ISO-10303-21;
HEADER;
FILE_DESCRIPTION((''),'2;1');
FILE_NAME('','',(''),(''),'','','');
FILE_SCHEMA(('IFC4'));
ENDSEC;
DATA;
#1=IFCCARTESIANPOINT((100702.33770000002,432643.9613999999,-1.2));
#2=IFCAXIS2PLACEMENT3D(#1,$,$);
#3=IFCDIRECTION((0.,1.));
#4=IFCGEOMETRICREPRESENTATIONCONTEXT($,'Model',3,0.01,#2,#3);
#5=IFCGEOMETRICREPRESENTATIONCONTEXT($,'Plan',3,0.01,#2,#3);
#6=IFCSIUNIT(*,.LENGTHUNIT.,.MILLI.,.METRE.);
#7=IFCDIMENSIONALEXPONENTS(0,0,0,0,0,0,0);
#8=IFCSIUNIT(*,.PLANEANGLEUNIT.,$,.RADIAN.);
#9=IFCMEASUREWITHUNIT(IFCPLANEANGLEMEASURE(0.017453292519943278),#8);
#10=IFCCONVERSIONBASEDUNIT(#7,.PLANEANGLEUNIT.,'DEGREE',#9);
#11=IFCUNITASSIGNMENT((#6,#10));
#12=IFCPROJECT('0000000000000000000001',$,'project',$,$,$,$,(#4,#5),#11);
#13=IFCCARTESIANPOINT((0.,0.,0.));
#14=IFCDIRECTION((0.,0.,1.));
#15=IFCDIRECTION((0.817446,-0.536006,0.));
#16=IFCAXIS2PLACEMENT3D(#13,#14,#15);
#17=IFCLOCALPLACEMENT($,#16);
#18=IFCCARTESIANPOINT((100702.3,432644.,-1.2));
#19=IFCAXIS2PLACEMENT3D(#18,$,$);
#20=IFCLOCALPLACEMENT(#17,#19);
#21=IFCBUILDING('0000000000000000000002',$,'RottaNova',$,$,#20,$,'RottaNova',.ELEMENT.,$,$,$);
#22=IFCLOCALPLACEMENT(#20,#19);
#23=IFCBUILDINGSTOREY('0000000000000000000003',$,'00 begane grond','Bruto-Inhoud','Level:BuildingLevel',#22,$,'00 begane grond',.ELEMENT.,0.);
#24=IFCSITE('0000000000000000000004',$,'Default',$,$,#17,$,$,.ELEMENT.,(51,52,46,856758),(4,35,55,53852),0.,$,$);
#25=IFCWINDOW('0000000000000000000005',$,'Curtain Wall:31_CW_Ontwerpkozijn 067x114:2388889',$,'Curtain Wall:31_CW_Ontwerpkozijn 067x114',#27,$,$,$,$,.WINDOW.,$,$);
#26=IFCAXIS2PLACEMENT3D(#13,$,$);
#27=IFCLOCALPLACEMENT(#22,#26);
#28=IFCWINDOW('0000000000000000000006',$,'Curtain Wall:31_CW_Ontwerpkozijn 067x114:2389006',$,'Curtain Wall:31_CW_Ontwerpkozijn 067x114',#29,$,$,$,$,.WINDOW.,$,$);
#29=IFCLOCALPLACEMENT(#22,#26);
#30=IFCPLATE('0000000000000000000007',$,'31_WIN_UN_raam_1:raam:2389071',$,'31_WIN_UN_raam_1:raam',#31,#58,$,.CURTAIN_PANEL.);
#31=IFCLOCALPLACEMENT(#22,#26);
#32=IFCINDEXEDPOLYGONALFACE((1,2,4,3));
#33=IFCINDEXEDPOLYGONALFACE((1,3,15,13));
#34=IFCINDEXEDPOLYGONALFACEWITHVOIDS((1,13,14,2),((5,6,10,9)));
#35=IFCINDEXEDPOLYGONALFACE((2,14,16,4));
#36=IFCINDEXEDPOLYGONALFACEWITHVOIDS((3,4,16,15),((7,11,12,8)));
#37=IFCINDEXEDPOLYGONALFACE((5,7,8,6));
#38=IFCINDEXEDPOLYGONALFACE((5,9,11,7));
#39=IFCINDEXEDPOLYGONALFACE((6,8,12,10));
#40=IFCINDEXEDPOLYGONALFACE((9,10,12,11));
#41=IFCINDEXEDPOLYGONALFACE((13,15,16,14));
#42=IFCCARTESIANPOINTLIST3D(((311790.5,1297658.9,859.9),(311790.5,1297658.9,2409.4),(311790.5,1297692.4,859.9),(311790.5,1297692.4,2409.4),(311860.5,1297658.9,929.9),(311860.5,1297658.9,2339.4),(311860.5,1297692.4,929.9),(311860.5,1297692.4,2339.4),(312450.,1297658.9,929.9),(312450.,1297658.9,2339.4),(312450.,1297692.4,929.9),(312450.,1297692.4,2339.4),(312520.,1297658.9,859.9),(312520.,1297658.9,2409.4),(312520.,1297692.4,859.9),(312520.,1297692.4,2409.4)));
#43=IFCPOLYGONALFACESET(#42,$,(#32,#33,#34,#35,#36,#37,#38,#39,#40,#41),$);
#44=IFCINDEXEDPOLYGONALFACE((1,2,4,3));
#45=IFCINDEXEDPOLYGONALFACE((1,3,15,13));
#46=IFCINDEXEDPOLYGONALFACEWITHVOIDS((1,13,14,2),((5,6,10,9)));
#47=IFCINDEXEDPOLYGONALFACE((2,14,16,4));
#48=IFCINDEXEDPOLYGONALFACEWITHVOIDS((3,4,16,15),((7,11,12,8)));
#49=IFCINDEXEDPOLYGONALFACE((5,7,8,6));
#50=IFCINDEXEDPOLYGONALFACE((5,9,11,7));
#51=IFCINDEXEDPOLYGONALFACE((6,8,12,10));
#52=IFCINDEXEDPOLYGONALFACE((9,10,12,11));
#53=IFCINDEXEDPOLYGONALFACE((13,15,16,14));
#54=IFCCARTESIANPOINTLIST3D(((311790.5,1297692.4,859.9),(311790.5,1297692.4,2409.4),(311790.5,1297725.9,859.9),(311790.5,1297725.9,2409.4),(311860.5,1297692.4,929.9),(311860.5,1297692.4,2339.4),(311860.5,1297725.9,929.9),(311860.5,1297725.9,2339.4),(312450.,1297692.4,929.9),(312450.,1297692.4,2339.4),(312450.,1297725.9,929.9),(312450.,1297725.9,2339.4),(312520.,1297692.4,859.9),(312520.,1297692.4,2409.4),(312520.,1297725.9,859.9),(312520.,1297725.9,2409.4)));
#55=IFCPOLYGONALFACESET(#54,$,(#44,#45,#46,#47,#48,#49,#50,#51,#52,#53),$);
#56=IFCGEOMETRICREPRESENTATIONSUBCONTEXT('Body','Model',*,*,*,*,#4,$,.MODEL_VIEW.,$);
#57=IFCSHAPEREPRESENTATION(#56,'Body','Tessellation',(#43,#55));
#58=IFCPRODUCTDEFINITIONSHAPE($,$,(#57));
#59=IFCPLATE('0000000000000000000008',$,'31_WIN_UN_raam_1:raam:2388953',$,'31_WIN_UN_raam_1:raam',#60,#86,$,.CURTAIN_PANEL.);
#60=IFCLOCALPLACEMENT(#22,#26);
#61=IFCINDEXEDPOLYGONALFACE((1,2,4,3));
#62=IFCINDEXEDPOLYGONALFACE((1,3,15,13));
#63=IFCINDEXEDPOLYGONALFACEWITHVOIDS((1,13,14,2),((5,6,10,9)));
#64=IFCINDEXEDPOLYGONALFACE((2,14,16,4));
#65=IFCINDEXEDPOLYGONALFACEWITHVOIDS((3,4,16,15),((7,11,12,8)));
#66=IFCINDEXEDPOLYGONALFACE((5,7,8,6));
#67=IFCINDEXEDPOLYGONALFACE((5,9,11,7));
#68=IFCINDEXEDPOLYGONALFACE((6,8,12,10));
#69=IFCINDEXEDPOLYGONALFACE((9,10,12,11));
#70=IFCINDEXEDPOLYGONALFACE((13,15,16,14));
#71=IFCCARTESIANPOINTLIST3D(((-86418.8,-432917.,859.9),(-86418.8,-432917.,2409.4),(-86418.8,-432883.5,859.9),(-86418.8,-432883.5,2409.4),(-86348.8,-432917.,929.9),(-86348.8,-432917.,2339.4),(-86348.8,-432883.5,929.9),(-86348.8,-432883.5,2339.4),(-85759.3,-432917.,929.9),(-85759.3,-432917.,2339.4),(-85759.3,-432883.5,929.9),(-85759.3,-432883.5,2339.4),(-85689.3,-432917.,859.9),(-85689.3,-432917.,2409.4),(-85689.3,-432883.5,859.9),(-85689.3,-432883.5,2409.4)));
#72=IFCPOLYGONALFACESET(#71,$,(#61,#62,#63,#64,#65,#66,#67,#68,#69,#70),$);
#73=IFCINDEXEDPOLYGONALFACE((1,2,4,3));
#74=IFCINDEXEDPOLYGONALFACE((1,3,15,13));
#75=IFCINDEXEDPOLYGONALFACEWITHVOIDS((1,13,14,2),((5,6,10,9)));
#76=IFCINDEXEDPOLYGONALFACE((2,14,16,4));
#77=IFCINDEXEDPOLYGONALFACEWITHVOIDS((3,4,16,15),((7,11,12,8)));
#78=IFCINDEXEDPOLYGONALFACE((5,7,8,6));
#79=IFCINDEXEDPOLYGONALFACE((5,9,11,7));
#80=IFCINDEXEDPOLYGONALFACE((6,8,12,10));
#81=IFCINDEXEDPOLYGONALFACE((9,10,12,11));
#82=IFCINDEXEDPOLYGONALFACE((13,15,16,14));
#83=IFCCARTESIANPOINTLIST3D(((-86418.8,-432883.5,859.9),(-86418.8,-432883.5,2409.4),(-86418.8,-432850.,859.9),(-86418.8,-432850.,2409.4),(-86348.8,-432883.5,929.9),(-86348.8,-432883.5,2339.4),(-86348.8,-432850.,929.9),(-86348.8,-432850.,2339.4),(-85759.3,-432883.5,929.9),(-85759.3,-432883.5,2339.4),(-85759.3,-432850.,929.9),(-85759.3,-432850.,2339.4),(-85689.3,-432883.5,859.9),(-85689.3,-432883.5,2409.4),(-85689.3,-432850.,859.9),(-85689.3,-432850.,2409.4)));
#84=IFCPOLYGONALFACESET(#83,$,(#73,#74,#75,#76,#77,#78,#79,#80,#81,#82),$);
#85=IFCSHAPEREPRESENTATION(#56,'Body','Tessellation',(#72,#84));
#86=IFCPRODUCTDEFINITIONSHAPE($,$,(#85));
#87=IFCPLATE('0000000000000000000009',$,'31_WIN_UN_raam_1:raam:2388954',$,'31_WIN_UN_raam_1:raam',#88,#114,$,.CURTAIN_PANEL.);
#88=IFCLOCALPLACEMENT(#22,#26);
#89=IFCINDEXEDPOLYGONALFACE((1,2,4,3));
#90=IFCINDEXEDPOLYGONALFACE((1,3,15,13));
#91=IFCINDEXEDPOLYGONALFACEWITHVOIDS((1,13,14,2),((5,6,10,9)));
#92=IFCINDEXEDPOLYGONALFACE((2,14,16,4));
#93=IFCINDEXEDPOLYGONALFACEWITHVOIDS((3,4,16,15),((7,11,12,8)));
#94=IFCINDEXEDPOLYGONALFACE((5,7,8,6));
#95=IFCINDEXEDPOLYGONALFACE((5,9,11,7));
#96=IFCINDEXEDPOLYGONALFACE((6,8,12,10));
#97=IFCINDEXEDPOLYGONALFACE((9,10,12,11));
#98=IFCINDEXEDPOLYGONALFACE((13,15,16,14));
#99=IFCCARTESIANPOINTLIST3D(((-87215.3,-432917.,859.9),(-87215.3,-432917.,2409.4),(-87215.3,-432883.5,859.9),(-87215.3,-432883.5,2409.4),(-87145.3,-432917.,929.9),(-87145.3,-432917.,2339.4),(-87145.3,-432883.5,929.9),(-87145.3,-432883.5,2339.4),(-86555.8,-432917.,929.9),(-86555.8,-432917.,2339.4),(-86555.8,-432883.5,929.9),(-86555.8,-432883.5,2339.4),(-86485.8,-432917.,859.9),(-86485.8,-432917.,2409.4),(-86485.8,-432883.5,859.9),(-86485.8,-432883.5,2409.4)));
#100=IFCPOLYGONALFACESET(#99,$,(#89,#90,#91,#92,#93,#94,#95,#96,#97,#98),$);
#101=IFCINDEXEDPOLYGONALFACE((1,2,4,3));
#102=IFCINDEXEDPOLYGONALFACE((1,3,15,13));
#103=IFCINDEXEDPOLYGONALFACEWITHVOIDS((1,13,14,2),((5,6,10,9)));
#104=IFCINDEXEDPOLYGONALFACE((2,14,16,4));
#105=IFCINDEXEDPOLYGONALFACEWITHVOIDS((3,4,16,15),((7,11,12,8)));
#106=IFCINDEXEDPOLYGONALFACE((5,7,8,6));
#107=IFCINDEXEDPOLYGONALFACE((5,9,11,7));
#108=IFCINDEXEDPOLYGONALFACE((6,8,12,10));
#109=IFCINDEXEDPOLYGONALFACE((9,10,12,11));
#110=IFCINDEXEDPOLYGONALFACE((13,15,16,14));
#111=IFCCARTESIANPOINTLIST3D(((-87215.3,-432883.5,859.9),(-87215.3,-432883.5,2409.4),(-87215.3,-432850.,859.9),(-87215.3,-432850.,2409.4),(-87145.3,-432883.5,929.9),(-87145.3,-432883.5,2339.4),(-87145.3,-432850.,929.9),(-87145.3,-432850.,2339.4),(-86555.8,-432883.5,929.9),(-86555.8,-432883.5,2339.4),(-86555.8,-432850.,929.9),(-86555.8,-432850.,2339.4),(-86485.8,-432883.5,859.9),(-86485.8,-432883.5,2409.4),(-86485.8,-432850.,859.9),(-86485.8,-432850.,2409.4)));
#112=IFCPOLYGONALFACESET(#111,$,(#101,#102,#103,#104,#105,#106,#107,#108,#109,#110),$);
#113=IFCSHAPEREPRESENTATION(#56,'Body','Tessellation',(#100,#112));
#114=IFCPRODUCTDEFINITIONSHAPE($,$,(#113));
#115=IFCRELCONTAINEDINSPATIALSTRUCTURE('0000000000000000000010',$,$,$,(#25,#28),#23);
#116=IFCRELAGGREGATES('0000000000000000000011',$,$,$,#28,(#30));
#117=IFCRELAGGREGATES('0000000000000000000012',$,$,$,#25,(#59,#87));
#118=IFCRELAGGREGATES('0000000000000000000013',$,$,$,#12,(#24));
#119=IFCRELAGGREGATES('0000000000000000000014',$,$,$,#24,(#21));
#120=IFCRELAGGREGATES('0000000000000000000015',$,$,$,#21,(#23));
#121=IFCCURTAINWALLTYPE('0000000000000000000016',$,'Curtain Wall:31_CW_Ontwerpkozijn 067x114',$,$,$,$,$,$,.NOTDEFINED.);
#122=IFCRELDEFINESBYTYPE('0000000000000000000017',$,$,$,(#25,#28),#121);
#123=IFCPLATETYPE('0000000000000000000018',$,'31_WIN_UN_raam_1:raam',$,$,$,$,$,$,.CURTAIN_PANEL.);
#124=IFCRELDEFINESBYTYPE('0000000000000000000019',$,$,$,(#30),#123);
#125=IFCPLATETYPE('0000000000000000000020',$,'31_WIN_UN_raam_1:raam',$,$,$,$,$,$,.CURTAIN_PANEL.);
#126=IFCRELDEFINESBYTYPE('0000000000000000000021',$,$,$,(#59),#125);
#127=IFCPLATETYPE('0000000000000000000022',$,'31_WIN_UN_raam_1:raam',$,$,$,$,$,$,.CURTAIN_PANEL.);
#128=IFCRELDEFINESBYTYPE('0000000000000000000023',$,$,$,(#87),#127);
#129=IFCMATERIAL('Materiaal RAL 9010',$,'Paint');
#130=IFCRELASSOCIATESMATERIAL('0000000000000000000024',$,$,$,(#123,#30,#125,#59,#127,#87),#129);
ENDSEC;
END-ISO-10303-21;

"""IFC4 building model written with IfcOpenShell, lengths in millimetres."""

from ifc_helpers import new_model, entity, si_unit, converted_unit, direction, frame, place, context, subcontext, project, spatial, indexed_curve, outline, extrude, source, transform, mapped, material, type_object, type_shapes, element, aggregate, save


model = new_model("IFC4")

# Units and contexts
model_context = context("Model", 3, precision=0.01, world=frame((100702.33770000002, 432643.9613999999, -1.2)), true_north=direction((0.0, 1.0)))
plan_context = context("Plan", 3, precision=0.01, world=frame((100702.33770000002, 432643.9613999999, -1.2)), true_north=direction((0.0, 1.0)))
body_context = subcontext(model_context, "Body", "Model", "MODEL_VIEW")
ifc_project = project(units=[si_unit("LENGTHUNIT", "METRE", prefix="MILLI"), converted_unit("PLANEANGLEUNIT", "DEGREE", entity("IfcPlaneAngleMeasure", 0.017453292519943278), si_unit("PLANEANGLEUNIT", "RADIAN"), dimensions=[0, 0, 0, 0, 0, 0, 0])], contexts=[model_context, plan_context])

# Site, building, storey
site_placement = place(None, frame((0.0, 0.0, 0.0), z_axis=(0.0, 0.0, 1.0), x_axis=(0.817446, -0.536006, 0.0)))
site = spatial("IfcSite", under=ifc_project, at=site_placement, Name="Default", CompositionType="ELEMENT", RefLatitude=(51, 52, 46, 856758), RefLongitude=(4, 35, 55, 53852), RefElevation=0.0)
building_placement = place(site_placement, frame((100702.3, 432644.0, -1.2)))
building = spatial("IfcBuilding", under=site, at=building_placement, Name="RottaNova", LongName="RottaNova", CompositionType="ELEMENT")
storey_placement = place(building_placement, frame((100702.3, 432644.0, -1.2)))
storey = spatial("IfcBuildingStorey", under=building, at=storey_placement, Name="00 begane grond", Description="Bruto-Inhoud", ObjectType="Level:BuildingLevel", LongName="00 begane grond", CompositionType="ELEMENT", Elevation=0.0)

# Shared definitions
curtain_wall_type = type_object("IfcCurtainWallType", Name="Curtain Wall:31_CW_Ontwerpkozijn 067x114", PredefinedType="NOTDEFINED")

# Windows
window_1_placement = place(storey_placement, frame((100702.3, 432644.0, -1.2)))
window_1 = element("IfcWindow", 1, at=window_1_placement, inside=storey, type_object=curtain_wall_type, Name="Curtain Wall:31_CW_Ontwerpkozijn 067x114:2388889", ObjectType="Curtain Wall:31_CW_Ontwerpkozijn 067x114", PredefinedType="WINDOW")
window_2_placement = place(storey_placement, frame((100702.3, 432644.0, -1.2)))
window_2 = element("IfcWindow", 2, at=window_2_placement, inside=storey, type_object=curtain_wall_type, Name="Curtain Wall:31_CW_Ontwerpkozijn 067x114:2389006", ObjectType="Curtain Wall:31_CW_Ontwerpkozijn 067x114", PredefinedType="WINDOW")

# Plates
ifc_material_1 = material(Name="Materiaal RAL 9010", Category="Paint")
plate_type_1 = type_object("IfcPlateType", Name="31_WIN_UN_raam_1:raam", PredefinedType="CURTAIN_PANEL", material=ifc_material_1)
shared_shape_1 = source(frame((100702.3, 432644.0, -1.2)), body_context, "Body", "SweptSolid", [
    extrude(outline(indexed_curve([(-364.7, -774.7), (364.7, -774.7), (364.7, 774.7), (-364.7, 774.7), (-364.7, -774.7)], self_intersect=False), holes=[indexed_curve([(-294.7, 704.7), (294.7, 704.7), (294.7, -704.8), (-294.7, -704.8), (-294.7, 704.7)], self_intersect=False)]), frame((0.0, -92.0, 774.8), z_axis=(0.0, 1.0, 0.0), x_axis=(1.0, 0.0, 0.0)), (0.0, 0.0, 1.0), 33.5),
    extrude(outline(indexed_curve([(-364.7, -774.7), (364.7, -774.7), (364.7, 774.7), (-364.7, 774.7), (-364.7, -774.7)], self_intersect=False), holes=[indexed_curve([(-294.7, 704.7), (294.7, 704.7), (294.7, -704.8), (-294.7, -704.8), (-294.7, 704.7)], self_intersect=False)]), frame((0.0, -58.5, 774.8), z_axis=(0.0, 1.0, 0.0), x_axis=(1.0, 0.0, 0.0)), (0.0, 0.0, 1.0), 33.5),
])
type_shapes(plate_type_1, [shared_shape_1])
plate_1_placement = place(window_2_placement, frame((10048.2, -181.0, 863.5)))
plate_1 = element("IfcPlate", 3, at=plate_1_placement, type_object=plate_type_1, material=ifc_material_1, Name="31_WIN_UN_raam_1:raam:2389071", ObjectType="31_WIN_UN_raam_1:raam", PredefinedType="CURTAIN_PANEL", context=body_context, shape_type="MappedRepresentation", body=[
    mapped(shared_shape_1, transform((100702.3, 432644.0, -1.2), scale=1.0)),
])
aggregate(window_2, [plate_1])
plate_type_2 = type_object("IfcPlateType", Name="31_WIN_UN_raam_1:raam", PredefinedType="CURTAIN_PANEL", material=ifc_material_1)
shared_shape_2 = source(frame((100702.3, 432644.0, -1.2)), body_context, "Body", "SweptSolid", [
    extrude(outline(indexed_curve([(-364.7, -774.7), (364.7, -774.7), (364.7, 774.7), (-364.7, 774.7), (-364.7, -774.7)], self_intersect=False), holes=[indexed_curve([(-294.7, 704.7), (294.7, 704.7), (294.7, -704.8), (-294.7, -704.8), (-294.7, 704.7)], self_intersect=False)]), frame((0.0, 58.5, 774.8), z_axis=(0.0, 1.0, 0.0), x_axis=(1.0, 0.0, 0.0)), (0.0, 0.0, 1.0), 33.5),
    extrude(outline(indexed_curve([(-364.7, -774.7), (364.7, -774.7), (364.7, 774.7), (-364.7, 774.7), (-364.7, -774.7)], self_intersect=False), holes=[indexed_curve([(-294.7, 704.7), (294.7, 704.7), (294.7, -704.8), (-294.7, -704.8), (-294.7, 704.7)], self_intersect=False)]), frame((0.0, 25.0, 774.8), z_axis=(0.0, 1.0, 0.0), x_axis=(1.0, 0.0, 0.0)), (0.0, 0.0, 1.0), 33.5),
])
type_shapes(plate_type_2, [shared_shape_2])
plate_2_placement = place(window_1_placement, frame((14648.3, -181.0, 863.5), z_axis=(0.0, 0.0, 1.0), x_axis=(-1.0, 0.0, 0.0)))
plate_2 = element("IfcPlate", 4, at=plate_2_placement, type_object=plate_type_2, material=ifc_material_1, Name="31_WIN_UN_raam_1:raam:2388953", ObjectType="31_WIN_UN_raam_1:raam", PredefinedType="CURTAIN_PANEL", context=body_context, shape_type="MappedRepresentation", body=[
    mapped(shared_shape_2, transform((100702.3, 432644.0, -1.2), scale=1.0)),
])
plate_type_3 = type_object("IfcPlateType", Name="31_WIN_UN_raam_1:raam", PredefinedType="CURTAIN_PANEL", material=ifc_material_1)
shared_shape_3 = source(frame((100702.3, 432644.0, -1.2)), body_context, "Body", "SweptSolid", [
    extrude(outline(indexed_curve([(-364.7, -774.7), (364.7, -774.7), (364.7, 774.7), (-364.7, 774.7), (-364.7, -774.7)], self_intersect=False), holes=[indexed_curve([(-294.7, 704.7), (294.7, 704.7), (294.7, -704.8), (-294.7, -704.8), (-294.7, 704.7)], self_intersect=False)]), frame((0.0, 58.5, 774.8), z_axis=(0.0, 1.0, 0.0), x_axis=(1.0, 0.0, 0.0)), (0.0, 0.0, 1.0), 33.5),
    extrude(outline(indexed_curve([(-364.7, -774.7), (364.7, -774.7), (364.7, 774.7), (-364.7, 774.7), (-364.7, -774.7)], self_intersect=False), holes=[indexed_curve([(-294.7, 704.7), (294.7, 704.7), (294.7, -704.8), (-294.7, -704.8), (-294.7, 704.7)], self_intersect=False)]), frame((0.0, 25.0, 774.8), z_axis=(0.0, 1.0, 0.0), x_axis=(1.0, 0.0, 0.0)), (0.0, 0.0, 1.0), 33.5),
])
type_shapes(plate_type_3, [shared_shape_3])
plate_3_placement = place(window_1_placement, frame((13851.8, -181.0, 863.5), z_axis=(0.0, 0.0, 1.0), x_axis=(-1.0, 0.0, 0.0)))
plate_3 = element("IfcPlate", 5, at=plate_3_placement, type_object=plate_type_3, material=ifc_material_1, Name="31_WIN_UN_raam_1:raam:2388954", ObjectType="31_WIN_UN_raam_1:raam", PredefinedType="CURTAIN_PANEL", context=body_context, shape_type="MappedRepresentation", body=[
    mapped(shared_shape_3, transform((100702.3, 432644.0, -1.2), scale=1.0)),
])
aggregate(window_1, [plate_2, plate_3])

save(model, "model.ifc")
